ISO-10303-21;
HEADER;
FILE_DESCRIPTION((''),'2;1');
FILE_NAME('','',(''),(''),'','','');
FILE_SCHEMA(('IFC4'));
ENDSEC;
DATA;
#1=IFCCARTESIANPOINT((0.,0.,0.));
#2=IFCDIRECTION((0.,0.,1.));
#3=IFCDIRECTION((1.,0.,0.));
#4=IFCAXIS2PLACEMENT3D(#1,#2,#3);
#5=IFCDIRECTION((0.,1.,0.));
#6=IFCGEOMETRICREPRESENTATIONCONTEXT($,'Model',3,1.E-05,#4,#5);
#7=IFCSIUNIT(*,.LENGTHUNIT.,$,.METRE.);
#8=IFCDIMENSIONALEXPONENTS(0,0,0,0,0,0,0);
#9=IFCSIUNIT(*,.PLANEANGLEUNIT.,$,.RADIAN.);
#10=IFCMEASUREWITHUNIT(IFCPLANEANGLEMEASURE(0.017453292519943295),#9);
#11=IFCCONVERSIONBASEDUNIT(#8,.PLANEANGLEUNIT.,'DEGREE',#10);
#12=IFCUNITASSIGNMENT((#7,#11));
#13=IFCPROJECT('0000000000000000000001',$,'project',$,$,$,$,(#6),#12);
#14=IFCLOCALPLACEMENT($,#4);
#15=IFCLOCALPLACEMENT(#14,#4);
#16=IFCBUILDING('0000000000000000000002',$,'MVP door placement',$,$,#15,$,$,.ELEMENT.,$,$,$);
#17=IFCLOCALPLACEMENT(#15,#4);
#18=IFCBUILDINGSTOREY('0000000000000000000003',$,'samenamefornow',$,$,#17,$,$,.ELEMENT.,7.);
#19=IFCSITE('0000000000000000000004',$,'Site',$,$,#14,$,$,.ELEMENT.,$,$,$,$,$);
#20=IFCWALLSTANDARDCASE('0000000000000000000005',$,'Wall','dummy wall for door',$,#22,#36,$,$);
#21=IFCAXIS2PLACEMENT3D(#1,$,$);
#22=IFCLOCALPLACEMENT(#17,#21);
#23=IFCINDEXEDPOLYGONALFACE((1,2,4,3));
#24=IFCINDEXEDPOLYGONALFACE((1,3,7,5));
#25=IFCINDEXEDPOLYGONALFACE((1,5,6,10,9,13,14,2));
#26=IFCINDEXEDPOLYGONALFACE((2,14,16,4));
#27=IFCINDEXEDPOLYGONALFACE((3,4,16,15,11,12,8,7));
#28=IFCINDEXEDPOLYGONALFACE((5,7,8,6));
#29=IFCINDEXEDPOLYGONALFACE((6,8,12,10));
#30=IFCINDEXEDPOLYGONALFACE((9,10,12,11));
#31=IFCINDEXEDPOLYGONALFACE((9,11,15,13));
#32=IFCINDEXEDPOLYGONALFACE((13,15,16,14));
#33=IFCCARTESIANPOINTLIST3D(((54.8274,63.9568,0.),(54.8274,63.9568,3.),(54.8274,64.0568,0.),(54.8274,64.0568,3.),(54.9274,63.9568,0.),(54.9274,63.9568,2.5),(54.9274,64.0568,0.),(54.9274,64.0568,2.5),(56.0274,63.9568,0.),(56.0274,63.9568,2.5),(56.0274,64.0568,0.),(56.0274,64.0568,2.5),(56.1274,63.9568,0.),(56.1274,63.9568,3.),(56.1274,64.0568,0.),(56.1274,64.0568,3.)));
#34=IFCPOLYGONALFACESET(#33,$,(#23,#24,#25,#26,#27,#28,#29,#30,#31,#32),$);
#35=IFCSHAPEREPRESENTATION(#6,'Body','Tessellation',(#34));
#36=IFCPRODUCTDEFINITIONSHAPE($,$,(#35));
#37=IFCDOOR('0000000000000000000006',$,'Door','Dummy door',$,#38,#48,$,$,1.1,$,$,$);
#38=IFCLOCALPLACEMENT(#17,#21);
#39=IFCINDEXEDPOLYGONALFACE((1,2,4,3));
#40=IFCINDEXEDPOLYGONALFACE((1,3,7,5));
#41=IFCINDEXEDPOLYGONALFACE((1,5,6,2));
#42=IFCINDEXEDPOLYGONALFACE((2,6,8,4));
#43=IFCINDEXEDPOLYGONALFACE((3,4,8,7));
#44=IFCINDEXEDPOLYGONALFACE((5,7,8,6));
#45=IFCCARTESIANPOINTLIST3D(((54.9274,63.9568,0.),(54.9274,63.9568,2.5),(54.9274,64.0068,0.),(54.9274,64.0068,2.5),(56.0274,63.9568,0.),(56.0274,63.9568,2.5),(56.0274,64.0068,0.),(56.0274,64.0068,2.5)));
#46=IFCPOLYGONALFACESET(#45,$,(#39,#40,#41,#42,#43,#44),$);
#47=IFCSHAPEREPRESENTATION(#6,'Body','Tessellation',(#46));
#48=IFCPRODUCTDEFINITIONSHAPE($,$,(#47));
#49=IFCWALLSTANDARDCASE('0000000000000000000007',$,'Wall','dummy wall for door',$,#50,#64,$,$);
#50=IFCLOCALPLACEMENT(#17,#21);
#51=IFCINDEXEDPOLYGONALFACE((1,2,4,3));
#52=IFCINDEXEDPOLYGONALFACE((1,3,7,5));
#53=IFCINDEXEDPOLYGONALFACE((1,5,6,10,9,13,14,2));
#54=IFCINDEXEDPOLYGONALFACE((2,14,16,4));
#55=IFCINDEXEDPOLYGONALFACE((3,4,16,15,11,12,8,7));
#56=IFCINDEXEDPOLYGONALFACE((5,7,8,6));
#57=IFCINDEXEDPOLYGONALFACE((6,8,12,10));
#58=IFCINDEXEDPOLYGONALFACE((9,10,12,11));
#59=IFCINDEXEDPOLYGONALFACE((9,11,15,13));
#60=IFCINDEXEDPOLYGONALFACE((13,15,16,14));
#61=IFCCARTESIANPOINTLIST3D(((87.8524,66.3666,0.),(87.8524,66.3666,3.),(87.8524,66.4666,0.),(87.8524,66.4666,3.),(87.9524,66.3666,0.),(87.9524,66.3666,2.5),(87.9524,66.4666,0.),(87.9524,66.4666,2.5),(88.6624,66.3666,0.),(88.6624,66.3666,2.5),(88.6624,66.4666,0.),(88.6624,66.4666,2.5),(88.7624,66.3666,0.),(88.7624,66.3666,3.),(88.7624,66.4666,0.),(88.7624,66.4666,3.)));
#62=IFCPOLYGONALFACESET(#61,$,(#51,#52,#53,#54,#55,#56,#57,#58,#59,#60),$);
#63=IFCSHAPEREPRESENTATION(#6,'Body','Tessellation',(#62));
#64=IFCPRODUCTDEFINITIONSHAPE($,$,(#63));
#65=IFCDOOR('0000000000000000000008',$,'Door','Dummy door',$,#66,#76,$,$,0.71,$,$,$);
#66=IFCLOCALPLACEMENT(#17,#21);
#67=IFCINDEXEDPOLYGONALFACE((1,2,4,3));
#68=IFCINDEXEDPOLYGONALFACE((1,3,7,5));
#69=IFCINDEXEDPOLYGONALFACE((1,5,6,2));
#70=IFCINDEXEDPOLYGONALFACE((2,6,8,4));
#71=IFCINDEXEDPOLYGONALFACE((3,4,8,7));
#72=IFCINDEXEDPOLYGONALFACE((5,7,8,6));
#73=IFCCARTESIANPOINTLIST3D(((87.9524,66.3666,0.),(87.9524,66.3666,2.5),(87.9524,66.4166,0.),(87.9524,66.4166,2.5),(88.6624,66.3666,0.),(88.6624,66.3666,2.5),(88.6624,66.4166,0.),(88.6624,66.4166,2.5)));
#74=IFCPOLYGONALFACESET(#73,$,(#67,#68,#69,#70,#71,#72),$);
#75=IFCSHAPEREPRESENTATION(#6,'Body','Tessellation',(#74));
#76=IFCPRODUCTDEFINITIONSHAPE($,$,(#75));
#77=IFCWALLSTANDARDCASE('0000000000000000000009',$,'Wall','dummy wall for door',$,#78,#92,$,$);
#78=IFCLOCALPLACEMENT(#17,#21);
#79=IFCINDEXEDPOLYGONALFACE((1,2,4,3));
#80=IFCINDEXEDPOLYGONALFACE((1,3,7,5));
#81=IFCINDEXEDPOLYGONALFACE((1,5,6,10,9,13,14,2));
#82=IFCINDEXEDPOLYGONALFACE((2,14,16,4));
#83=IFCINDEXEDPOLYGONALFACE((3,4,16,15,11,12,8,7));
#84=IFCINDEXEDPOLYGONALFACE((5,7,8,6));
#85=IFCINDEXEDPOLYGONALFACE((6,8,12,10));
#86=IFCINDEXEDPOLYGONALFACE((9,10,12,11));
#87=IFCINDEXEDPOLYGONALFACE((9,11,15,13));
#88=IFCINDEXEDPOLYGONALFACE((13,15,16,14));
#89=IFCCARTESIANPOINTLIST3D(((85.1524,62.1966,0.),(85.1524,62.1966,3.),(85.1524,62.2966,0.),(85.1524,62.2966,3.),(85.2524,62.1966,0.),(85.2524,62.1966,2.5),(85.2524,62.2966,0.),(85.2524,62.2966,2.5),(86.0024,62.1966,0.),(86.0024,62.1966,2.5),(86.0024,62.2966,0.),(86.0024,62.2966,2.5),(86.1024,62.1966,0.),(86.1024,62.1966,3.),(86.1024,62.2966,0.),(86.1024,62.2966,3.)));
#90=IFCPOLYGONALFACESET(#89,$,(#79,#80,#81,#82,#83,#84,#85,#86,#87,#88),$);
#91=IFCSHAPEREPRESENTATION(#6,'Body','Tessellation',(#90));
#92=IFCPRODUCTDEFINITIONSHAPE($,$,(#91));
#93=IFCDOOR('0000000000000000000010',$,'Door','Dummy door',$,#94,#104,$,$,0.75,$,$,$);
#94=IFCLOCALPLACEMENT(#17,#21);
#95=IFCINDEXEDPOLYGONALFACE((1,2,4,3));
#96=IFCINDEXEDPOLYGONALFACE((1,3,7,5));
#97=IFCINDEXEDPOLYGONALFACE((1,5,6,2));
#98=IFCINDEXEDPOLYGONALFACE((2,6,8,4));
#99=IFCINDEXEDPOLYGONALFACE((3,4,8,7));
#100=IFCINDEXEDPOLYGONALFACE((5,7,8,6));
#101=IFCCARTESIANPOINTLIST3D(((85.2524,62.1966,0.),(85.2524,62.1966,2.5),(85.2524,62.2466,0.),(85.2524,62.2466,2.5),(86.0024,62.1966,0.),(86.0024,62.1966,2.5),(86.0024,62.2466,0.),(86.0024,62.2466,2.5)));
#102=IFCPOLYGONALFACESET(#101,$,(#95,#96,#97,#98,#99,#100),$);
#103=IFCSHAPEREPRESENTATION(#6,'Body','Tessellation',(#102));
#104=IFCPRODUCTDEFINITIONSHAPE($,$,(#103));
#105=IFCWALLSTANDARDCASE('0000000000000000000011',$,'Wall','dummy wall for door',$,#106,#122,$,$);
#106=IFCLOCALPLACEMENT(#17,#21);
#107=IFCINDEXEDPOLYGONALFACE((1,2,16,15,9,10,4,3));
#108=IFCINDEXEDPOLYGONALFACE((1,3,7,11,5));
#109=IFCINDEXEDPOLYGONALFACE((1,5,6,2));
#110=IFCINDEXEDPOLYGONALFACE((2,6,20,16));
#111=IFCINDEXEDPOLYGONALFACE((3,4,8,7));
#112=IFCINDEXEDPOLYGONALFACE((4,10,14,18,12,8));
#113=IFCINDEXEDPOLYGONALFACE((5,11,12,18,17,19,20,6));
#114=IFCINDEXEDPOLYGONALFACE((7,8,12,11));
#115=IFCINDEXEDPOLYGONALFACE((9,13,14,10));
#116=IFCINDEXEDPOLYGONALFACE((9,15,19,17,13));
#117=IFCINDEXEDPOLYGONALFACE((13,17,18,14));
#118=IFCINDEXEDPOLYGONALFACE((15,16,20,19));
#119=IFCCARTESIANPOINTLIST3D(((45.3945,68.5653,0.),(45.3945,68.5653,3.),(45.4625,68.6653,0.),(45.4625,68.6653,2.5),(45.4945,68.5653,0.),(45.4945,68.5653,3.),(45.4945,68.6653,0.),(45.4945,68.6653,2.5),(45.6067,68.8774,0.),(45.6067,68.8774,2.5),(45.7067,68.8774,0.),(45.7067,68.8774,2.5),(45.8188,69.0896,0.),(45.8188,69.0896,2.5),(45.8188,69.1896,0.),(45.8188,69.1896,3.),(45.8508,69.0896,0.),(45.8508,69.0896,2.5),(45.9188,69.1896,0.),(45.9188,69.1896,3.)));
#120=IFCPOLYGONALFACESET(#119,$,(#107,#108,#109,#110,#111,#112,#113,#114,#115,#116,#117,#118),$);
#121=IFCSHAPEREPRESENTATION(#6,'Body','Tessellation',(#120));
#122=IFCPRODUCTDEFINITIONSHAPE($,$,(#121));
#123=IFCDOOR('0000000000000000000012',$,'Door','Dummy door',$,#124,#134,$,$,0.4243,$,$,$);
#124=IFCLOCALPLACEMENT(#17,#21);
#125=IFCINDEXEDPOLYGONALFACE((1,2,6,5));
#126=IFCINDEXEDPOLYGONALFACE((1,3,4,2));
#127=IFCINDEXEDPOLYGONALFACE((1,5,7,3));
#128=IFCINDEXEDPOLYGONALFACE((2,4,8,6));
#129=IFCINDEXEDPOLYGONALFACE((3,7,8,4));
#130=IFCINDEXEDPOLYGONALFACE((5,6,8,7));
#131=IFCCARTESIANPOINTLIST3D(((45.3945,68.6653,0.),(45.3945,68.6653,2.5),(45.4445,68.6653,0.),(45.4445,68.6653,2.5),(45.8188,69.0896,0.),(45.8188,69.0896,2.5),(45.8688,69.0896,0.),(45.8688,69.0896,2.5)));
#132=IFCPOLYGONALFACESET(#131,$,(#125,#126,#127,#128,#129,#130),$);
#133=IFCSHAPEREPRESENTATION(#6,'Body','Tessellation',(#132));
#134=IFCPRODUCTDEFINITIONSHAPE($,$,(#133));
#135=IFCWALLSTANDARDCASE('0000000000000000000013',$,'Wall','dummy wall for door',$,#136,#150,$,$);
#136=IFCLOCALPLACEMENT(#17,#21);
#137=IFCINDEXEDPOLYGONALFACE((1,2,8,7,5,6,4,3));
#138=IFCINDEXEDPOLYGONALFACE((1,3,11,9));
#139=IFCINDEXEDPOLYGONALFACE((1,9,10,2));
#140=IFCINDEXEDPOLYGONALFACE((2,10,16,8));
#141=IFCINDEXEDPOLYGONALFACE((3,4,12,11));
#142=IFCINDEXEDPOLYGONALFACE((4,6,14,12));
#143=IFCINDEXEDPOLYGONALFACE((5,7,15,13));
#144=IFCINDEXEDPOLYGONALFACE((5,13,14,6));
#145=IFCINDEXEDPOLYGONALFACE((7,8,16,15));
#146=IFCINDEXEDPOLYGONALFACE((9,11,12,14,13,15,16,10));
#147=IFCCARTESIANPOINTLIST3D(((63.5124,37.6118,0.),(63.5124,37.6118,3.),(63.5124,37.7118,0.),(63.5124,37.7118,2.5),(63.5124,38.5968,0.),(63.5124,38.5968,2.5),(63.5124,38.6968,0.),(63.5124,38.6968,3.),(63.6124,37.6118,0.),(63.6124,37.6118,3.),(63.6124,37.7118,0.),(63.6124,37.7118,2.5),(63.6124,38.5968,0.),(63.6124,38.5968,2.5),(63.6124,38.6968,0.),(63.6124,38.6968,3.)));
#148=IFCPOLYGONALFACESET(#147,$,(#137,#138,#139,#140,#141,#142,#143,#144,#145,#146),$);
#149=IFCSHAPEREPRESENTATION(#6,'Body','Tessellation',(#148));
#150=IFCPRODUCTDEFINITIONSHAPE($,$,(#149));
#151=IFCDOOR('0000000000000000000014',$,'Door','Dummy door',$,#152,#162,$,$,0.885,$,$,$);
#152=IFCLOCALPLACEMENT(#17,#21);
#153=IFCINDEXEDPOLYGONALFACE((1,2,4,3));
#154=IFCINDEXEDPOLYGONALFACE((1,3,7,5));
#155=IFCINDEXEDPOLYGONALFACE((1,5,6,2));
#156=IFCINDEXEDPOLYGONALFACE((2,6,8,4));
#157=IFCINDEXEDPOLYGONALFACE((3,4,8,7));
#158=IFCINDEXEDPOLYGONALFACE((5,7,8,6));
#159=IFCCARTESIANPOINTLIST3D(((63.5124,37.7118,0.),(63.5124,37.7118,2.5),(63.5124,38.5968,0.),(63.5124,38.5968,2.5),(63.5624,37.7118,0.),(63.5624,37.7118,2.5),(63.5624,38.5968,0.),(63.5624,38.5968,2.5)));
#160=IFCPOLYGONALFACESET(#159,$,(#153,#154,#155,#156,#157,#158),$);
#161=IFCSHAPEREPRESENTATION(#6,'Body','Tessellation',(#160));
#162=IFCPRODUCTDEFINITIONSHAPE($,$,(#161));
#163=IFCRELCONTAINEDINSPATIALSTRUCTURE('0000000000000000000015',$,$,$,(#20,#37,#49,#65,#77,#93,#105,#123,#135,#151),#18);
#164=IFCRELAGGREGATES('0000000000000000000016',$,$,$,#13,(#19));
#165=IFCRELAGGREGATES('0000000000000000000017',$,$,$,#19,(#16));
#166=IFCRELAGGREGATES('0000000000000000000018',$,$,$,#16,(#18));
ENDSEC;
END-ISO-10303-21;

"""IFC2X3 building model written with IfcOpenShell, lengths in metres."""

from ifc_helpers import new_model, entity, si_unit, converted_unit, direction, origin_with_axes, place, context, project, spatial, polyline, outline, extrude, element, fill, save


model = new_model("IFC2X3")

# Units and contexts
model_context = context("Model", 3, precision=1e-05, world=origin_with_axes(), true_north=direction((0.0, 1.0, 0.0)))
ifc_project = project(units=[si_unit("LENGTHUNIT", "METRE"), converted_unit("PLANEANGLEUNIT", "DEGREE", entity("IfcPlaneAngleMeasure", 0.017453292519943295), si_unit("PLANEANGLEUNIT", "RADIAN"), dimensions=[0, 0, 0, 0, 0, 0, 0])], contexts=[model_context])

# Site, building, storey
site_placement = place(None, origin_with_axes())
site = spatial("IfcSite", under=ifc_project, at=site_placement, Name="Site", CompositionType="ELEMENT")
building_placement = place(site_placement, origin_with_axes())
building = spatial("IfcBuilding", under=site, at=building_placement, Name="MVP door placement", CompositionType="ELEMENT")
storey_placement = place(building_placement, origin_with_axes())
storey = spatial("IfcBuildingStorey", under=building, at=storey_placement, Name="samenamefornow", CompositionType="ELEMENT", Elevation=7.0)

# Walls, openings, doors
wall_1_placement = place(storey_placement, origin_with_axes())
wall_1 = element("IfcWallStandardCase", 1, at=wall_1_placement, inside=storey, Name="Wall", Description="dummy wall for door", context=model_context, shape_type="SweptSolid", body=[
    extrude(outline(polyline([(56.1274, 63.9568, 0.0), (54.8274, 63.9568, 0.0), (54.8274, 64.0568, 0.0), (56.1274, 64.0568, 0.0), (56.1274, 63.9568, 0.0)])), origin_with_axes(), (0.0, 0.0, 1.0), 3.0),
])
opening_1_placement = place(wall_1_placement, origin_with_axes())
opening_1 = element("IfcOpeningElement", 2, at=opening_1_placement, cuts=wall_1, context=model_context, shape_type="SweptSolid", body=[
    extrude(outline(polyline([(56.0274, 63.9568, 0.0), (54.9274, 63.9568, 0.0), (54.9274, 64.0568, 0.0), (56.0274, 64.0568, 0.0), (56.0274, 63.9568, 0.0)])), origin_with_axes(), (0.0, 0.0, 1.0), 2.5),
])
door_1_placement = place(opening_1_placement, origin_with_axes())
door_1 = element("IfcDoor", 3, at=door_1_placement, inside=storey, Name="Door", Description="Dummy door", OverallWidth=1.1, context=model_context, shape_type="SweptSolid", body=[
    extrude(outline(polyline([(56.0274, 63.9568, 0.0), (54.9274, 63.9568, 0.0), (54.9274, 64.0068, 0.0), (56.0274, 64.0068, 0.0), (56.0274, 63.9568, 0.0)])), origin_with_axes(), (0.0, 0.0, 1.0), 2.5),
])
fill(opening_1, door_1)
wall_2_placement = place(storey_placement, origin_with_axes())
wall_2 = element("IfcWallStandardCase", 4, at=wall_2_placement, inside=storey, Name="Wall", Description="dummy wall for door", context=model_context, shape_type="SweptSolid", body=[
    extrude(outline(polyline([(87.8524, 66.3666, 0.0), (88.7624, 66.3666, 0.0), (88.7624, 66.4666, 0.0), (87.8524, 66.4666, 0.0), (87.8524, 66.3666, 0.0)])), origin_with_axes(), (0.0, 0.0, 1.0), 3.0),
])
opening_2_placement = place(wall_2_placement, origin_with_axes())
opening_2 = element("IfcOpeningElement", 5, at=opening_2_placement, cuts=wall_2, context=model_context, shape_type="SweptSolid", body=[
    extrude(outline(polyline([(87.9524, 66.3666, 0.0), (88.6624, 66.3666, 0.0), (88.6624, 66.4666, 0.0), (87.9524, 66.4666, 0.0), (87.9524, 66.3666, 0.0)])), origin_with_axes(), (0.0, 0.0, 1.0), 2.5),
])
door_2_placement = place(opening_2_placement, origin_with_axes())
door_2 = element("IfcDoor", 6, at=door_2_placement, inside=storey, Name="Door", Description="Dummy door", OverallWidth=0.71, context=model_context, shape_type="SweptSolid", body=[
    extrude(outline(polyline([(87.9524, 66.3666, 0.0), (88.6624, 66.3666, 0.0), (88.6624, 66.4166, 0.0), (87.9524, 66.4166, 0.0), (87.9524, 66.3666, 0.0)])), origin_with_axes(), (0.0, 0.0, 1.0), 2.5),
])
fill(opening_2, door_2)
wall_3_placement = place(storey_placement, origin_with_axes())
wall_3 = element("IfcWallStandardCase", 7, at=wall_3_placement, inside=storey, Name="Wall", Description="dummy wall for door", context=model_context, shape_type="SweptSolid", body=[
    extrude(outline(polyline([(85.1524, 62.1966, 0.0), (86.1024, 62.1966, 0.0), (86.1024, 62.2966, 0.0), (85.1524, 62.2966, 0.0), (85.1524, 62.1966, 0.0)])), origin_with_axes(), (0.0, 0.0, 1.0), 3.0),
])
opening_3_placement = place(wall_3_placement, origin_with_axes())
opening_3 = element("IfcOpeningElement", 8, at=opening_3_placement, cuts=wall_3, context=model_context, shape_type="SweptSolid", body=[
    extrude(outline(polyline([(85.2524, 62.1966, 0.0), (86.0024, 62.1966, 0.0), (86.0024, 62.2966, 0.0), (85.2524, 62.2966, 0.0), (85.2524, 62.1966, 0.0)])), origin_with_axes(), (0.0, 0.0, 1.0), 2.5),
])
door_3_placement = place(opening_3_placement, origin_with_axes())
door_3 = element("IfcDoor", 9, at=door_3_placement, inside=storey, Name="Door", Description="Dummy door", OverallWidth=0.75, context=model_context, shape_type="SweptSolid", body=[
    extrude(outline(polyline([(85.2524, 62.1966, 0.0), (86.0024, 62.1966, 0.0), (86.0024, 62.2466, 0.0), (85.2524, 62.2466, 0.0), (85.2524, 62.1966, 0.0)])), origin_with_axes(), (0.0, 0.0, 1.0), 2.5),
])
fill(opening_3, door_3)
wall_4_placement = place(storey_placement, origin_with_axes())
wall_4 = element("IfcWallStandardCase", 10, at=wall_4_placement, inside=storey, Name="Wall", Description="dummy wall for door", context=model_context, shape_type="SweptSolid", body=[
    extrude(outline(polyline([(45.8188, 69.1896, 0.0), (45.3945, 68.5653, 0.0), (45.4945, 68.5653, 0.0), (45.9188, 69.1896, 0.0), (45.8188, 69.1896, 0.0)])), origin_with_axes(), (0.0, 0.0, 1.0), 3.0),
])
opening_4_placement = place(wall_4_placement, origin_with_axes())
opening_4 = element("IfcOpeningElement", 11, at=opening_4_placement, cuts=wall_4, context=model_context, shape_type="SweptSolid", body=[
    extrude(outline(polyline([(45.8188, 69.0896, 0.0), (45.3945, 68.6653, 0.0), (45.4945, 68.6653, 0.0), (45.9188, 69.0896, 0.0), (45.8188, 69.0896, 0.0)])), origin_with_axes(), (0.0, 0.0, 1.0), 2.5),
])
door_4_placement = place(opening_4_placement, origin_with_axes())
door_4 = element("IfcDoor", 12, at=door_4_placement, inside=storey, Name="Door", Description="Dummy door", OverallWidth=0.4243, context=model_context, shape_type="SweptSolid", body=[
    extrude(outline(polyline([(45.8188, 69.0896, 0.0), (45.3945, 68.6653, 0.0), (45.4445, 68.6653, 0.0), (45.8688, 69.0896, 0.0), (45.8188, 69.0896, 0.0)])), origin_with_axes(), (0.0, 0.0, 1.0), 2.5),
])
fill(opening_4, door_4)
wall_5_placement = place(storey_placement, origin_with_axes())
wall_5 = element("IfcWallStandardCase", 13, at=wall_5_placement, inside=storey, Name="Wall", Description="dummy wall for door", context=model_context, shape_type="SweptSolid", body=[
    extrude(outline(polyline([(63.5124, 37.6118, 0.0), (63.5124, 38.6968, 0.0), (63.6124, 38.6968, 0.0), (63.6124, 37.6118, 0.0), (63.5124, 37.6118, 0.0)])), origin_with_axes(), (0.0, 0.0, 1.0), 3.0),
])
opening_5_placement = place(wall_5_placement, origin_with_axes())
opening_5 = element("IfcOpeningElement", 14, at=opening_5_placement, cuts=wall_5, context=model_context, shape_type="SweptSolid", body=[
    extrude(outline(polyline([(63.5124, 37.7118, 0.0), (63.5124, 38.5968, 0.0), (63.6124, 38.5968, 0.0), (63.6124, 37.7118, 0.0), (63.5124, 37.7118, 0.0)])), origin_with_axes(), (0.0, 0.0, 1.0), 2.5),
])
door_5_placement = place(opening_5_placement, origin_with_axes())
door_5 = element("IfcDoor", 15, at=door_5_placement, inside=storey, Name="Door", Description="Dummy door", OverallWidth=0.885, context=model_context, shape_type="SweptSolid", body=[
    extrude(outline(polyline([(63.5124, 37.7118, 0.0), (63.5124, 38.5968, 0.0), (63.5624, 38.5968, 0.0), (63.5624, 37.7118, 0.0), (63.5124, 37.7118, 0.0)])), origin_with_axes(), (0.0, 0.0, 1.0), 2.5),
])
fill(opening_5, door_5)

save(model, "model.ifc")
